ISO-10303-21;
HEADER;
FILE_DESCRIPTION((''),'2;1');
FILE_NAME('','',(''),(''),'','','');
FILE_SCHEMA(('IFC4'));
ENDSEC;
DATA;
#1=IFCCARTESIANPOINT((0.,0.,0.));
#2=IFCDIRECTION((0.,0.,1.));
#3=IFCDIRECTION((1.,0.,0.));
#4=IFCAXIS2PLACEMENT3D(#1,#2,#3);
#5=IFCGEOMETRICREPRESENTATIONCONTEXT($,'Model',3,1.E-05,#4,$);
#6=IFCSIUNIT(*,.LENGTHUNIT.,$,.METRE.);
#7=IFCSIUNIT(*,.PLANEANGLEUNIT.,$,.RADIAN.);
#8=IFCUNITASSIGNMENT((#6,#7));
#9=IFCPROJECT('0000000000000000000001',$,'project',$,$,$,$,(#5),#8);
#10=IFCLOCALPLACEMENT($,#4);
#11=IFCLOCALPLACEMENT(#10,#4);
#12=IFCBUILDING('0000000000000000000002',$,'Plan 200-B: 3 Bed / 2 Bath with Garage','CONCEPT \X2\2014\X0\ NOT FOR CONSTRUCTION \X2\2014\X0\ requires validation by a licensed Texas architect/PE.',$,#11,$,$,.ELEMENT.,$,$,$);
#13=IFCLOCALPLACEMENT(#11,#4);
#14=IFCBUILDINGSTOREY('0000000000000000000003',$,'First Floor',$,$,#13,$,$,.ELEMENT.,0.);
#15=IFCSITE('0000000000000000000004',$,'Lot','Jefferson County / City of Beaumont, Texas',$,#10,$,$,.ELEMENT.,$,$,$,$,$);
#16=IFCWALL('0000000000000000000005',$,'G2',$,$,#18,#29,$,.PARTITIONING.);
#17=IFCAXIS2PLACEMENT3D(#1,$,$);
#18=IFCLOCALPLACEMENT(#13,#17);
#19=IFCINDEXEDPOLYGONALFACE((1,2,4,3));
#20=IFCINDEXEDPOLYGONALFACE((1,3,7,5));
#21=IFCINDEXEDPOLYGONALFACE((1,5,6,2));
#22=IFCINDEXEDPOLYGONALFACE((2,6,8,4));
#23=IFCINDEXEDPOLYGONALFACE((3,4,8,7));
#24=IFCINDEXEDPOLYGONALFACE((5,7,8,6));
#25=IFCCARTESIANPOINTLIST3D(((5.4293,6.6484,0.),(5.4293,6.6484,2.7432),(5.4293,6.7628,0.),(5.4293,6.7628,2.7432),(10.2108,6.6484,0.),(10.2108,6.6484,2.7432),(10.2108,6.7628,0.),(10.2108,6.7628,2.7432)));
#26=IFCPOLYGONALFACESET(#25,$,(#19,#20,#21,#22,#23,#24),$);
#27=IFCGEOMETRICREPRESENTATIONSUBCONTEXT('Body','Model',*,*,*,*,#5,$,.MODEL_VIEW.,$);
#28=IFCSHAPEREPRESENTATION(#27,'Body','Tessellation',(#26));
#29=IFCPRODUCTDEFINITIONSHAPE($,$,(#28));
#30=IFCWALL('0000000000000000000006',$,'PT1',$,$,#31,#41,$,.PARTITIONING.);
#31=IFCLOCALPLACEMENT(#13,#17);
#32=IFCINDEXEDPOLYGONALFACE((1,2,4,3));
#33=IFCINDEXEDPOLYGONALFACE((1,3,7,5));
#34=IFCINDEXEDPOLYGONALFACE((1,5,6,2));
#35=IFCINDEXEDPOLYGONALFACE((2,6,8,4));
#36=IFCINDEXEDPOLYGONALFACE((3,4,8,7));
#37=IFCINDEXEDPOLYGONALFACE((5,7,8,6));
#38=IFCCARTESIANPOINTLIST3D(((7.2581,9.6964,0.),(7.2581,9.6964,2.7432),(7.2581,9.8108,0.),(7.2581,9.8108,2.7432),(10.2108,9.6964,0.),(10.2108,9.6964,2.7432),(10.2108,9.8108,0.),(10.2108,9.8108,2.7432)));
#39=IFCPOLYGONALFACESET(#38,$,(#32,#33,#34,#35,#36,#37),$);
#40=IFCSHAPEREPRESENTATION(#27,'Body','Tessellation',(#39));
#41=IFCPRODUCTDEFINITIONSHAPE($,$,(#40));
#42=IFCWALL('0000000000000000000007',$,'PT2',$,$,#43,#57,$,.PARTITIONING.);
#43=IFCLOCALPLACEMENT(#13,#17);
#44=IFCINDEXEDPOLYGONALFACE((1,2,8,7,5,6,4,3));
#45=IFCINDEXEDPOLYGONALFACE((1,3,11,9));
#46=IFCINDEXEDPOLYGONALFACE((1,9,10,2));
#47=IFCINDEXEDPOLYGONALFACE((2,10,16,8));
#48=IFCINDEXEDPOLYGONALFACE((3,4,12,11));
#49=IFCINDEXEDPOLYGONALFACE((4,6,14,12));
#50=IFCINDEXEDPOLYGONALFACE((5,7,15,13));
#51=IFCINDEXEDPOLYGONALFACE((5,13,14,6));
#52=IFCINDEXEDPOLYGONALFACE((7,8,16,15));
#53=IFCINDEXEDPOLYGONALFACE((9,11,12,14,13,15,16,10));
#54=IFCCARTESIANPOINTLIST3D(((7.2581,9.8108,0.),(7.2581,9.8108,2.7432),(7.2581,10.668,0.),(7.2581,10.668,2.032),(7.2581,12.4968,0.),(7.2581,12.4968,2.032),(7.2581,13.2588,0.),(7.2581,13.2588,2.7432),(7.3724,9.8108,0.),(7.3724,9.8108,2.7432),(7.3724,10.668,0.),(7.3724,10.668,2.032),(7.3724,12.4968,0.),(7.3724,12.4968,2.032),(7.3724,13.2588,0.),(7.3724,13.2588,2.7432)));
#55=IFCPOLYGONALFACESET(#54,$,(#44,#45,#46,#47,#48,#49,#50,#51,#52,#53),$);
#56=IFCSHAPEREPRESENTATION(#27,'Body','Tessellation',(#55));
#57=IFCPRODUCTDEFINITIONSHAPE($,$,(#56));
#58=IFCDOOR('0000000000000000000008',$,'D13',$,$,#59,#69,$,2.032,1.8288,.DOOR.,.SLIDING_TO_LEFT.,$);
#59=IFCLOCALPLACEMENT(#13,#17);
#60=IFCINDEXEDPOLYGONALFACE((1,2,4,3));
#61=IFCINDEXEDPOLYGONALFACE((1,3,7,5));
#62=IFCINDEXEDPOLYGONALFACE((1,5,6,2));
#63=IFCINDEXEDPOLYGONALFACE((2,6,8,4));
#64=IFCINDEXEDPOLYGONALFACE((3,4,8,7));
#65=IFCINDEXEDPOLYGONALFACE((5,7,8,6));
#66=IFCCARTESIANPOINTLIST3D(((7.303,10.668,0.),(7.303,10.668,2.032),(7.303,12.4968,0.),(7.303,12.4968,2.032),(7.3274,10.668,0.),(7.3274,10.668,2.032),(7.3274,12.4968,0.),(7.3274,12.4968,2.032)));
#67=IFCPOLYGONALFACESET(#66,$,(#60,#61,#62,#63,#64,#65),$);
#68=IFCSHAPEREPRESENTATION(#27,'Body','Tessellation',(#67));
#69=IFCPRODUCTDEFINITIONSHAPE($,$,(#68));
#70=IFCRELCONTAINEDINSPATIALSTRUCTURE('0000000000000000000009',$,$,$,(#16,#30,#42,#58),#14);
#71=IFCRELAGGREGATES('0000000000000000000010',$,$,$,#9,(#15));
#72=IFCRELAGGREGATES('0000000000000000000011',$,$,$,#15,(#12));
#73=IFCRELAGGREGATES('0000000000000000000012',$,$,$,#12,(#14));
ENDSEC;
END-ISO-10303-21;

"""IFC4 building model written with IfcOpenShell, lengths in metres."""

from ifc_helpers import new_model, si_unit, frame, frame_2d, origin_with_axes, place, context, subcontext, project, spatial, rectangle, extrude, element, fill, save


model = new_model("IFC4")

# Units and contexts
model_context = context("Model", 3, precision=1e-05, world=origin_with_axes())
body_context = subcontext(model_context, "Body", "Model", "MODEL_VIEW")
ifc_project = project(units=[si_unit("LENGTHUNIT", "METRE"), si_unit("PLANEANGLEUNIT", "RADIAN")], contexts=[model_context])

# Site, building, storey
site_placement = place(None, origin_with_axes())
site = spatial("IfcSite", under=ifc_project, at=site_placement, Name="Lot", Description="Jefferson County / City of Beaumont, Texas", CompositionType="ELEMENT")
building_placement = place(site_placement, origin_with_axes())
building = spatial("IfcBuilding", under=site, at=building_placement, Name="Plan 200-B: 3 Bed / 2 Bath with Garage", Description="CONCEPT — NOT FOR CONSTRUCTION — requires validation by a licensed Texas architect/PE.", CompositionType="ELEMENT")
storey_placement = place(building_placement, origin_with_axes())
storey = spatial("IfcBuildingStorey", under=building, at=storey_placement, Name="First Floor", CompositionType="ELEMENT", Elevation=0.0)

# Walls
wall_1_placement = place(storey_placement, frame((5.4293, 6.7056, 0.0), z_axis=(0.0, 0.0, 1.0), x_axis=(1.0, 0.0, 0.0)))
element("IfcWall", 1, at=wall_1_placement, inside=storey, Name="G2", PredefinedType="PARTITIONING", context=body_context, shape_type="SweptSolid", body=[
    extrude(rectangle(XDim=4.7816, YDim=0.1143, at=frame_2d((2.3908, 0.0), x_axis=(1.0, 0.0))), origin_with_axes(), (0.0, 0.0, 1.0), 2.7432),
])
wall_2_placement = place(storey_placement, frame((7.2581, 9.7536, 0.0), z_axis=(0.0, 0.0, 1.0), x_axis=(1.0, 0.0, 0.0)))
element("IfcWall", 2, at=wall_2_placement, inside=storey, Name="PT1", PredefinedType="PARTITIONING", context=body_context, shape_type="SweptSolid", body=[
    extrude(rectangle(XDim=2.9527, YDim=0.1143, at=frame_2d((1.4764, 0.0), x_axis=(1.0, 0.0))), origin_with_axes(), (0.0, 0.0, 1.0), 2.7432),
])

# Wall, opening, door
wall_3_placement = place(storey_placement, frame((7.3152, 9.8108, 0.0), z_axis=(0.0, 0.0, 1.0), x_axis=(0.0, 1.0, 0.0)))
wall_3 = element("IfcWall", 3, at=wall_3_placement, inside=storey, Name="PT2", PredefinedType="PARTITIONING", context=body_context, shape_type="SweptSolid", body=[
    extrude(rectangle(XDim=3.4481, YDim=0.1143, at=frame_2d((1.724, 0.0), x_axis=(1.0, 0.0))), origin_with_axes(), (0.0, 0.0, 1.0), 2.7432),
])
opening_1_placement = place(wall_3_placement, frame((0.8573, 0.0, 0.0), z_axis=(0.0, 0.0, 1.0), x_axis=(1.0, 0.0, 0.0)))
opening_1 = element("IfcOpeningElement", 4, at=opening_1_placement, cuts=wall_3, PredefinedType="OPENING", context=body_context, shape_type="SweptSolid", body=[
    extrude(rectangle(XDim=1.8288, YDim=0.1448, at=frame_2d((0.9144, 0.0), x_axis=(1.0, 0.0))), origin_with_axes(), (0.0, 0.0, 1.0), 2.032),
])
door_1_placement = place(opening_1_placement, origin_with_axes())
door_1 = element("IfcDoor", 5, at=door_1_placement, inside=storey, Name="D13", OperationType="SLIDING_TO_LEFT", OverallHeight=2.032, OverallWidth=1.8288, PredefinedType="DOOR", context=body_context, shape_type="SweptSolid", body=[
    extrude(rectangle(XDim=1.8288, YDim=0.0244, at=frame_2d((0.9144, 0.0), x_axis=(1.0, 0.0))), origin_with_axes(), (0.0, 0.0, 1.0), 2.032),
])
fill(opening_1, door_1)

save(model, "model.ifc")
